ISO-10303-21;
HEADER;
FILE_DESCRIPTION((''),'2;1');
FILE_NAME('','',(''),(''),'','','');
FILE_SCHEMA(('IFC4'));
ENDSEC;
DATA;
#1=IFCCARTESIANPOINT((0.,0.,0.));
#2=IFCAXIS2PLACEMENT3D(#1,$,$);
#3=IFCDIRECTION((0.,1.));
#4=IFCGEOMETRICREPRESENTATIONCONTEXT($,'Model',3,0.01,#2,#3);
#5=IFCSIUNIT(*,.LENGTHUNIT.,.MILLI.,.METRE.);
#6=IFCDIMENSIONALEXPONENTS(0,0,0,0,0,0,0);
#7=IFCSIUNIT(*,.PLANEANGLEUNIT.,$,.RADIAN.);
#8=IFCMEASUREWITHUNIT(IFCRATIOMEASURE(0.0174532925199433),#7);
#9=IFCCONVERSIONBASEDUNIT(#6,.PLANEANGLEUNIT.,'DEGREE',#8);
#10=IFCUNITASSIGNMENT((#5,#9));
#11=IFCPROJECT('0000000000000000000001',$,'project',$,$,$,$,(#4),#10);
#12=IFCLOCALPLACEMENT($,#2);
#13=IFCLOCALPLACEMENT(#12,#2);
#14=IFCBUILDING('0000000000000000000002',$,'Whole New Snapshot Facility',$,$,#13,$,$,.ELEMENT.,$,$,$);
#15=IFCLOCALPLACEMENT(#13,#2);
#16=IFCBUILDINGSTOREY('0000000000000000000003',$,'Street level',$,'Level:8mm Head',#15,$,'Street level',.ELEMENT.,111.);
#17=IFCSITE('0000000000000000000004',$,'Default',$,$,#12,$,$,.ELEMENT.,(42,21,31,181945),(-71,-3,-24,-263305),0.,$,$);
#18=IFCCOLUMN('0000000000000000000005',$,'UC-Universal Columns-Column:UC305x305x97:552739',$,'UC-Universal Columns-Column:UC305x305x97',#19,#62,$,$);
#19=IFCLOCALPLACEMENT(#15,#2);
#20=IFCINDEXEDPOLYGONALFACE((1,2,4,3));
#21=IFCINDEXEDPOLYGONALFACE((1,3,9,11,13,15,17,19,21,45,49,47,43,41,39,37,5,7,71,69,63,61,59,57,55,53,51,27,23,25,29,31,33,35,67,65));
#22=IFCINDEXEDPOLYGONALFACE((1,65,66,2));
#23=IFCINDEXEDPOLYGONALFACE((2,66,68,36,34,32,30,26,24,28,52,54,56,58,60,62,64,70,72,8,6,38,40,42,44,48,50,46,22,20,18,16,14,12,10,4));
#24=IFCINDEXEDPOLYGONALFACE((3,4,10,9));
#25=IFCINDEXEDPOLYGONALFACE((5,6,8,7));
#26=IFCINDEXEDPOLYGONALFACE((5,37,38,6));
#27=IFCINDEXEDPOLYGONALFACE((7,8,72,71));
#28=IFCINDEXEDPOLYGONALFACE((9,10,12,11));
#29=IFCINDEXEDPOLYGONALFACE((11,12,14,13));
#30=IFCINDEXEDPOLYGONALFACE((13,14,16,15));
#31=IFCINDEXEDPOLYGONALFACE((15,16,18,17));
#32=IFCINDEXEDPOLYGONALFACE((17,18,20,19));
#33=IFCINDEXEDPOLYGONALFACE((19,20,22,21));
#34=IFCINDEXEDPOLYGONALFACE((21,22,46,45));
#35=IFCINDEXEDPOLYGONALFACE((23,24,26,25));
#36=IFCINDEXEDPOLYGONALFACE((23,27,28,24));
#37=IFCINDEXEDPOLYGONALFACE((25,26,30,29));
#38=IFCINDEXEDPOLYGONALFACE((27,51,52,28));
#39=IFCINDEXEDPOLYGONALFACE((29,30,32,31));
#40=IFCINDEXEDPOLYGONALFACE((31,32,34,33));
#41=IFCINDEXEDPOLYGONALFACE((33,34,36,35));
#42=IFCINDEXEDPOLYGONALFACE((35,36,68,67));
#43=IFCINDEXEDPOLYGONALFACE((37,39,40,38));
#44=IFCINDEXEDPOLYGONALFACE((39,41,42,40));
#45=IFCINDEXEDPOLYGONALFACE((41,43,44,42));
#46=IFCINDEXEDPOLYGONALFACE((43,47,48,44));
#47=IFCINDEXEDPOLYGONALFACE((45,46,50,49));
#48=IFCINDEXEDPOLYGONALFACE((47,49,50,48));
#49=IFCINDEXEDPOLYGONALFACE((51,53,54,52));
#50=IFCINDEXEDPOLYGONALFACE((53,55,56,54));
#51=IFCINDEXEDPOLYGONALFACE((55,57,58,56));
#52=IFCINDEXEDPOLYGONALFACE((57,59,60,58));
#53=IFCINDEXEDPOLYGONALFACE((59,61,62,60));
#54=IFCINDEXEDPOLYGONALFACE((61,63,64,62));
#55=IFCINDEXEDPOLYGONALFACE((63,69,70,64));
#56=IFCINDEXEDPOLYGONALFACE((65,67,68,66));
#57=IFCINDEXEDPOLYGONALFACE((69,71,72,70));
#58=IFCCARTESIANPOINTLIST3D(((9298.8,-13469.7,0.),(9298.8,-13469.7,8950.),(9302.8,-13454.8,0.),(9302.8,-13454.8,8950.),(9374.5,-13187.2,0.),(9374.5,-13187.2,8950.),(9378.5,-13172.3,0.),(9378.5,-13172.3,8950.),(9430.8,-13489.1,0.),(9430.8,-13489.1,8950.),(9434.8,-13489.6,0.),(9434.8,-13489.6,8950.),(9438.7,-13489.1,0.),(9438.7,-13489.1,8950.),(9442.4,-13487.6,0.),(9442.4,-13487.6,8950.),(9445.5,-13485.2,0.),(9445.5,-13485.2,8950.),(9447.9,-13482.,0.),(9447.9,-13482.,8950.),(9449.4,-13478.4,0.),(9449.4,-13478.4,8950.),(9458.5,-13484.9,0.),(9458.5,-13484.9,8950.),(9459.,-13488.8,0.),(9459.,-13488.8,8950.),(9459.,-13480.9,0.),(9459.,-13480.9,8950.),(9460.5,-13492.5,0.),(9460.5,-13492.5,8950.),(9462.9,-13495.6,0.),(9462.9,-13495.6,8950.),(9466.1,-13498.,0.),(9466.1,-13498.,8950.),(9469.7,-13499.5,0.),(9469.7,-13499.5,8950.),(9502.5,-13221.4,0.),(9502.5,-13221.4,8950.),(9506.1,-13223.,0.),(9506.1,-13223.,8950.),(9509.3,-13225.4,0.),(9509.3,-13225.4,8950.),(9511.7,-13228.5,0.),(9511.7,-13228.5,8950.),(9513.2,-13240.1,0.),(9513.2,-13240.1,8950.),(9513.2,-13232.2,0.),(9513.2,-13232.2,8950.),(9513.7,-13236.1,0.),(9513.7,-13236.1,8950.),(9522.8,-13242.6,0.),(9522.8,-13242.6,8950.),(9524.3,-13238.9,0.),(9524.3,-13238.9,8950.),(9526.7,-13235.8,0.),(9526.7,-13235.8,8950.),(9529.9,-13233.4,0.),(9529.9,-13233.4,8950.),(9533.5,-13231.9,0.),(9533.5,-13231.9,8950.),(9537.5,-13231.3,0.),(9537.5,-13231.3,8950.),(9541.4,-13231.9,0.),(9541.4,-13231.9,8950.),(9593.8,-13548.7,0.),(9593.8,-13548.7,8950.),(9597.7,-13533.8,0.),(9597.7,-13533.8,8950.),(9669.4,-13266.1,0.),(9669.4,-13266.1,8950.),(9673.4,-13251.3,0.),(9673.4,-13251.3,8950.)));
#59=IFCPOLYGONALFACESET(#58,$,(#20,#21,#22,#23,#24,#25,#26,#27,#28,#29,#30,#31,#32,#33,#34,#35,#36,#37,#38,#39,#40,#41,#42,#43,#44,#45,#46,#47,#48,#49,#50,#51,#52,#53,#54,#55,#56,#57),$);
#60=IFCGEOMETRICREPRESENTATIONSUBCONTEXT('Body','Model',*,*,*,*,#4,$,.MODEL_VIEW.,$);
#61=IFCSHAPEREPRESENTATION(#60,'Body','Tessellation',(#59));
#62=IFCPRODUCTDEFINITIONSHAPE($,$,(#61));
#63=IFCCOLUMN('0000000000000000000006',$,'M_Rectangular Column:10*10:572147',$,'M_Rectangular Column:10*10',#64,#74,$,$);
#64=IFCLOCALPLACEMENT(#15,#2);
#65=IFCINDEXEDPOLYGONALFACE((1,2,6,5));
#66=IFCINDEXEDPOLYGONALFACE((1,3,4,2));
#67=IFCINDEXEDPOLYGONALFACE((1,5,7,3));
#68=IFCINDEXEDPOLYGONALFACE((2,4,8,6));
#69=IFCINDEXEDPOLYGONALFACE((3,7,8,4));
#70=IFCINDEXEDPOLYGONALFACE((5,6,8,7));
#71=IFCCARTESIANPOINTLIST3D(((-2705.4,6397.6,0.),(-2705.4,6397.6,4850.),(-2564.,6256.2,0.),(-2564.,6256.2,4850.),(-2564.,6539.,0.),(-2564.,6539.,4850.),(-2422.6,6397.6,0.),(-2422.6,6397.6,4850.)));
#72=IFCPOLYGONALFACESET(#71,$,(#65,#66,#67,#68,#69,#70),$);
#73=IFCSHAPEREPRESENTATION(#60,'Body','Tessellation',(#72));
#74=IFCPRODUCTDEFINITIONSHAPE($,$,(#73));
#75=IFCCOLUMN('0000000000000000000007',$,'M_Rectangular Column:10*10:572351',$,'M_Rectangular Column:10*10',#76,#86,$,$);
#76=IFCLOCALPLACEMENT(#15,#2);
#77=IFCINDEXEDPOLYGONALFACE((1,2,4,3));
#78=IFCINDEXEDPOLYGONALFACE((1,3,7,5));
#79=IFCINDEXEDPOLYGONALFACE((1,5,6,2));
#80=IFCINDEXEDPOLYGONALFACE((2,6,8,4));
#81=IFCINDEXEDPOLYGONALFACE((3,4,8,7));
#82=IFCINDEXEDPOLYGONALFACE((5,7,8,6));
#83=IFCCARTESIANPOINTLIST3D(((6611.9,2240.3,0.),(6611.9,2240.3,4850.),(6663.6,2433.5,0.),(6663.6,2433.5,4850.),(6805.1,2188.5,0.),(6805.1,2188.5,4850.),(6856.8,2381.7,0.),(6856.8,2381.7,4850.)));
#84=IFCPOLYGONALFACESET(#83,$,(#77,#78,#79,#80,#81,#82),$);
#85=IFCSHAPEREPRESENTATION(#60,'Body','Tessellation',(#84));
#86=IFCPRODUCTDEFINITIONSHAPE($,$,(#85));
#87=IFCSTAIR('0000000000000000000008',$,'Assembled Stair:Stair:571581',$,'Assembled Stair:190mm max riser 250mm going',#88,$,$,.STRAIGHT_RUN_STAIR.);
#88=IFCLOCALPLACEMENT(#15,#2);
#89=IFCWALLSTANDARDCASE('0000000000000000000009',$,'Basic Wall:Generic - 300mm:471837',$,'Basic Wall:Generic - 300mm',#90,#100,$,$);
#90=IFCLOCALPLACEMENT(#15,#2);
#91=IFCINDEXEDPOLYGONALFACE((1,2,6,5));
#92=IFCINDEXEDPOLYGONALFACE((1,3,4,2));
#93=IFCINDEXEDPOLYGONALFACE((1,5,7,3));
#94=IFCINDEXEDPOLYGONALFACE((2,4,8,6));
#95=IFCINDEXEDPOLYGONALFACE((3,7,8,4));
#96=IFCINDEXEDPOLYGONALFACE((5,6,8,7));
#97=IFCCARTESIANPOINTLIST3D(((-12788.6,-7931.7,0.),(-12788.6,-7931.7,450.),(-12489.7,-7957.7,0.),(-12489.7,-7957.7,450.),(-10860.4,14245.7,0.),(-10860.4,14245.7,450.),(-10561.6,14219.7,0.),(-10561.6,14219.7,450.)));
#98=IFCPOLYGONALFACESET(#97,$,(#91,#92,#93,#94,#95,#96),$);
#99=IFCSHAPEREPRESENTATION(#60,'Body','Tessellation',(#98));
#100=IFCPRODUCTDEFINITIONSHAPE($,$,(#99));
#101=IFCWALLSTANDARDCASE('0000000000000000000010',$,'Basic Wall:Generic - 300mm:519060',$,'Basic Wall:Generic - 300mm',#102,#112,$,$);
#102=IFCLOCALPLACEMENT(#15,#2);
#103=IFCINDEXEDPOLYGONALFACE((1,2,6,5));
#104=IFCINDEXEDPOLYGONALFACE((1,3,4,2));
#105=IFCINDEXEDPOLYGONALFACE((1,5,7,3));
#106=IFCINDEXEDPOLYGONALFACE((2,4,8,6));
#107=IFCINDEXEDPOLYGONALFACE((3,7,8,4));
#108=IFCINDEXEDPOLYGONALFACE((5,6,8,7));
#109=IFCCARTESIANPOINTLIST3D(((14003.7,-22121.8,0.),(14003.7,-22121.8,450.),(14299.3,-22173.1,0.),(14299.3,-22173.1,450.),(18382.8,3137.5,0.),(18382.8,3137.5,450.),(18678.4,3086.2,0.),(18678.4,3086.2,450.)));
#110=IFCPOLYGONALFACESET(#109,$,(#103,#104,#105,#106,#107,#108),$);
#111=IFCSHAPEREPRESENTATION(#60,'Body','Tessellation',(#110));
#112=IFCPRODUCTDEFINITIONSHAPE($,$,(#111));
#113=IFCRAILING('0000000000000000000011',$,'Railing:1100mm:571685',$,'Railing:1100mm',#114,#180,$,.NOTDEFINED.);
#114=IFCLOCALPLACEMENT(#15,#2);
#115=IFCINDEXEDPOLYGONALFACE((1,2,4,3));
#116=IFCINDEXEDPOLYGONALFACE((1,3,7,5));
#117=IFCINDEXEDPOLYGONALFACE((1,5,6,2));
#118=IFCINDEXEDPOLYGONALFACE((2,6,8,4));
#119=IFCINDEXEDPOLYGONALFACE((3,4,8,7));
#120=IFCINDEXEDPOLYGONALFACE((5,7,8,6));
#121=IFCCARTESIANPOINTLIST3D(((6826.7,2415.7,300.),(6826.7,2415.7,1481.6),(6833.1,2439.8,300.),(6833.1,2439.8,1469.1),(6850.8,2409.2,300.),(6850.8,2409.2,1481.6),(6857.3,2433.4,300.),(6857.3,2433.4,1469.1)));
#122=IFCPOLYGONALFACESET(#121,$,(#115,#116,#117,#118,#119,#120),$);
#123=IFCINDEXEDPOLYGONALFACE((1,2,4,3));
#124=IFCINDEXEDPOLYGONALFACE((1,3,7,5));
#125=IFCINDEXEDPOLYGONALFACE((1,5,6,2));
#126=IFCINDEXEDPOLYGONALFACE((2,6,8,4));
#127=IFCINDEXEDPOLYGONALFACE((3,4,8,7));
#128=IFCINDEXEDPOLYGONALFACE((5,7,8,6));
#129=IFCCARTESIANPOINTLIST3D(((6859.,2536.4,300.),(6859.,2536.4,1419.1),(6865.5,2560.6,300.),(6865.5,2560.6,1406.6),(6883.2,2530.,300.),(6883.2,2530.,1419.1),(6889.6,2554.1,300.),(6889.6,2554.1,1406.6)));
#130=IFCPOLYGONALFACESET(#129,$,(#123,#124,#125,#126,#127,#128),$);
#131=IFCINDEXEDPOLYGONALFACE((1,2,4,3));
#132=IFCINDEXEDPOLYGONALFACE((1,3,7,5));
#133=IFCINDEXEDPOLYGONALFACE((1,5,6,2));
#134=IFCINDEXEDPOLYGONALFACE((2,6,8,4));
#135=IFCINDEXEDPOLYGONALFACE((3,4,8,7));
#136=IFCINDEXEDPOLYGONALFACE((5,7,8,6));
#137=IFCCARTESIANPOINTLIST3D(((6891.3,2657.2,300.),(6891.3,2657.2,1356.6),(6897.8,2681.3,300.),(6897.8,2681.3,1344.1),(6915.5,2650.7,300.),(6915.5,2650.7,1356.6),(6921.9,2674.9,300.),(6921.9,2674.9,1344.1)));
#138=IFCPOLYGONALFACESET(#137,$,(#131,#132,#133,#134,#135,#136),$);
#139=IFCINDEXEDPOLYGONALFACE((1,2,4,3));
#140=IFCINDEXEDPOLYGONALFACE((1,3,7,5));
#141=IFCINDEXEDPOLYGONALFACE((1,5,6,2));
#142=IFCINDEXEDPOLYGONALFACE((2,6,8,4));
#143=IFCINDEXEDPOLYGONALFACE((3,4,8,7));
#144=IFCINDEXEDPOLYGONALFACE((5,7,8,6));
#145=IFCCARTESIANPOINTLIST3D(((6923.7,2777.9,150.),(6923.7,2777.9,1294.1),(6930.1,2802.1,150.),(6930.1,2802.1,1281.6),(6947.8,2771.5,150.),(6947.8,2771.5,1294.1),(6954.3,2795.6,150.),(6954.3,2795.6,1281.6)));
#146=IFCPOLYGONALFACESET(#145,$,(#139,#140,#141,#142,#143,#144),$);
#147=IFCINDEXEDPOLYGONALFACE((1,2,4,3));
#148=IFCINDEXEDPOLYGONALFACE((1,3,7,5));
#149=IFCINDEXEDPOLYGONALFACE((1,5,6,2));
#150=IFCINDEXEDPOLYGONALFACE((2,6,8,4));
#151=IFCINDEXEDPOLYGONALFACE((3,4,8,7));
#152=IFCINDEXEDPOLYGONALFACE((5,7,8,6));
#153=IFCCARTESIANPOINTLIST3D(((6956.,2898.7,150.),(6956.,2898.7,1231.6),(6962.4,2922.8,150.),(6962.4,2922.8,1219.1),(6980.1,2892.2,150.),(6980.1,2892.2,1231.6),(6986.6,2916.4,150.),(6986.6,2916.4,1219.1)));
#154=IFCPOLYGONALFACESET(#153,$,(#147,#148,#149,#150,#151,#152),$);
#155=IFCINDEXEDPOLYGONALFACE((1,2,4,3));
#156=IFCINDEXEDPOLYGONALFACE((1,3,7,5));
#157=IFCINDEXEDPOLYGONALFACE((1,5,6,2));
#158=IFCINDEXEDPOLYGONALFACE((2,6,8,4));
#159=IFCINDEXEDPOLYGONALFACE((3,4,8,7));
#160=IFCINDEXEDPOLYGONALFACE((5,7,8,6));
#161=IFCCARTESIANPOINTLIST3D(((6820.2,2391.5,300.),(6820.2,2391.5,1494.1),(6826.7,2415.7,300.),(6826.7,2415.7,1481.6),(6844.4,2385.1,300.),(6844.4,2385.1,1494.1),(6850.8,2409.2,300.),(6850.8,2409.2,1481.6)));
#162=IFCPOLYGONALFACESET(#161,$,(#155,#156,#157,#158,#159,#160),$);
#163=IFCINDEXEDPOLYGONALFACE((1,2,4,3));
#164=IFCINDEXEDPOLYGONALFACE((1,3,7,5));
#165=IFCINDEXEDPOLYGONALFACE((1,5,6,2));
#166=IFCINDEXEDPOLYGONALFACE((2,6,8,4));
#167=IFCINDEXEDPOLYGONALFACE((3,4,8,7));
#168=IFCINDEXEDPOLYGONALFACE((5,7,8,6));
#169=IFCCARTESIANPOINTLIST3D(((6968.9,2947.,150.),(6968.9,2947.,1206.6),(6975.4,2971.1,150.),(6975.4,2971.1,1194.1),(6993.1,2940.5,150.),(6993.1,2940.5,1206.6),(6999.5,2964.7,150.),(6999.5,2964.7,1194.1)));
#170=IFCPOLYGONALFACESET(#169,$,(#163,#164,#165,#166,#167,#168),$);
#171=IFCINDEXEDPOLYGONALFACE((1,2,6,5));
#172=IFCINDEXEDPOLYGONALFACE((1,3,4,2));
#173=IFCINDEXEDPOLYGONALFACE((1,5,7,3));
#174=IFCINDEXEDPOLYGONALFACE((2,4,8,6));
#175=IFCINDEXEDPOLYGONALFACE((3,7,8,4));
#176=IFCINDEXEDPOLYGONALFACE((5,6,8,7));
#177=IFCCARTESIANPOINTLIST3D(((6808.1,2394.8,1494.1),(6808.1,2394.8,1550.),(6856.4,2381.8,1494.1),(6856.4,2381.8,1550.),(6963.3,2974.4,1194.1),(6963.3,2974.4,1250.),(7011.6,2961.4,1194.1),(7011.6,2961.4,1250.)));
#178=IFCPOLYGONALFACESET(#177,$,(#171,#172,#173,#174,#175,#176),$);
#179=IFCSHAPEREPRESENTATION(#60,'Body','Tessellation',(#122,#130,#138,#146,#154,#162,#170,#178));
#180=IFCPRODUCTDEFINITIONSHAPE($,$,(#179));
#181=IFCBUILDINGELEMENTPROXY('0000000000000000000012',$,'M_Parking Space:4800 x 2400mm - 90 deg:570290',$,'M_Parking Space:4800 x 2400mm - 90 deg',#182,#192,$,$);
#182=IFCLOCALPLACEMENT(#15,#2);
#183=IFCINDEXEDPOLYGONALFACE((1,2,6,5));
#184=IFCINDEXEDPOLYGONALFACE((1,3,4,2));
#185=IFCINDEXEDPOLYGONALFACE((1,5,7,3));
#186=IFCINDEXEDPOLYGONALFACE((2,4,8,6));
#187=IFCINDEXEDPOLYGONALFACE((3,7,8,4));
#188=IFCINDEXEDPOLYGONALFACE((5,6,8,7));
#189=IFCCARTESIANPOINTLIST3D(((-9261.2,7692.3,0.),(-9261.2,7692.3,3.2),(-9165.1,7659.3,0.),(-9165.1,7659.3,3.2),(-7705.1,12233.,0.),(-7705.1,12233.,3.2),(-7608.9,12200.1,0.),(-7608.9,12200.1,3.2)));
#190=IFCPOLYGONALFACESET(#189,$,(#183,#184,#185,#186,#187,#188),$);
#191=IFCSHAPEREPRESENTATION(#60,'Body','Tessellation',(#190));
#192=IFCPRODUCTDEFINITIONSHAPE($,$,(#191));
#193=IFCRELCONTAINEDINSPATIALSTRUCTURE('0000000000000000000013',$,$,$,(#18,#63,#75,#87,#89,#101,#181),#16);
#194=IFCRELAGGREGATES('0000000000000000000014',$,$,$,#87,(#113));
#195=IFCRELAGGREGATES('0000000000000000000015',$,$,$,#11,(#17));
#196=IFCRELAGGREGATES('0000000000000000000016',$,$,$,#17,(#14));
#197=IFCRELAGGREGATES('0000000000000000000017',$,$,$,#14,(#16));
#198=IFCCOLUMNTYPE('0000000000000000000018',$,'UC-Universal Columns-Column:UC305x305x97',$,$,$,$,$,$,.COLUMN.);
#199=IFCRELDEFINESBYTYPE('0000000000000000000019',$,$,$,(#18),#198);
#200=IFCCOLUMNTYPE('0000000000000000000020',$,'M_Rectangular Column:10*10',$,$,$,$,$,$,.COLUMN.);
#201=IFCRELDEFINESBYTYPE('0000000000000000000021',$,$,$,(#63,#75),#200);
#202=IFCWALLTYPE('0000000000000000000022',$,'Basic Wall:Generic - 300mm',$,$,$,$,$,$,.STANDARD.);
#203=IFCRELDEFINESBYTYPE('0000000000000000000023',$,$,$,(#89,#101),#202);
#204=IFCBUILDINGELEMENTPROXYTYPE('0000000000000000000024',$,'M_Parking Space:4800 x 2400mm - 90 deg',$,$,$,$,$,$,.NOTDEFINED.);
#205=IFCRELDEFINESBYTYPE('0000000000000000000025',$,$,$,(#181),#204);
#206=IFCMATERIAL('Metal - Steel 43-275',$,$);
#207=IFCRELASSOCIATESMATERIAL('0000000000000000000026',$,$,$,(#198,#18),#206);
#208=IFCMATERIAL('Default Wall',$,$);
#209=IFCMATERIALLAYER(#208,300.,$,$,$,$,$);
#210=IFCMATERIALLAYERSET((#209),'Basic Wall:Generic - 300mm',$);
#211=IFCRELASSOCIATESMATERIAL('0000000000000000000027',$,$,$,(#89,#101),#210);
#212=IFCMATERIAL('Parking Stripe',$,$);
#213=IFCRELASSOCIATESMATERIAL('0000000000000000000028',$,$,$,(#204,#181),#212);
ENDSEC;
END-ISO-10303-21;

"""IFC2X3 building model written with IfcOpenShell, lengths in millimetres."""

from ifc_helpers import new_model, entity, si_unit, converted_unit, direction, frame, frame_2d, origin, origin_2d_with_axis, place, context, subcontext, project, spatial, polyline, rectangle, i_section, outline, extrude, source, transform, mapped, material, layer, layer_set, layer_usage, type_object, type_shapes, element, aggregate, save


model = new_model("IFC2X3")

# Units and contexts
model_context = context("Model", 3, precision=0.01, world=origin(), true_north=direction((0.0, 1.0)))
body_context = subcontext(model_context, "Body", "Model", "MODEL_VIEW")
ifc_project = project(units=[si_unit("LENGTHUNIT", "METRE", prefix="MILLI"), converted_unit("PLANEANGLEUNIT", "DEGREE", entity("IfcRatioMeasure", 0.0174532925199433), si_unit("PLANEANGLEUNIT", "RADIAN"), dimensions=[0, 0, 0, 0, 0, 0, 0])], contexts=[model_context])

# Site, building, storey
site_placement = place(None, origin())
site = spatial("IfcSite", under=ifc_project, at=site_placement, Name="Default", CompositionType="ELEMENT", RefLatitude=(42, 21, 31, 181945), RefLongitude=(-71, -3, -24, -263305), RefElevation=0.0)
building_placement = place(site_placement, origin())
building = spatial("IfcBuilding", under=site, at=building_placement, Name="Whole New Snapshot Facility", CompositionType="ELEMENT")
storey_placement = place(building_placement, origin())
storey = spatial("IfcBuildingStorey", under=building, at=storey_placement, Name="Street level", ObjectType="Level:8mm Head", LongName="Street level", CompositionType="ELEMENT", Elevation=111.0)

# Columns
ifc_material_1 = material(Name="Metal - Steel 43-275")
column_type_1 = type_object("IfcColumnType", Name="UC-Universal Columns-Column:UC305x305x97", PredefinedType="COLUMN", material=ifc_material_1)
shared_shape_1 = source(origin(), body_context, "Body", "SweptSolid", [
    extrude(i_section(OverallWidth=305.3, OverallDepth=307.9, WebThickness=9.9, FlangeThickness=15.4, FilletRadius=15.2, at=frame_2d((0.0, 0.0), x_axis=(0.0, 1.0))), frame((0.0, 0.0, 0.0), z_axis=(0.0, 0.0, 1.0), x_axis=(0.0, -1.0, 0.0)), (0.0, 0.0, 1.0), 8950.0),
])
type_shapes(column_type_1, [shared_shape_1])
column_placement = place(storey_placement, frame((9486.1, -13360.5, 0.0), z_axis=(0.0, 0.0, 1.0), x_axis=(0.965983, -0.258607, 0.0)))
element("IfcColumn", 1, at=column_placement, inside=storey, type_object=column_type_1, material=ifc_material_1, Name="UC-Universal Columns-Column:UC305x305x97:552739", ObjectType="UC-Universal Columns-Column:UC305x305x97", context=body_context, shape_type="MappedRepresentation", body=[
    mapped(shared_shape_1, transform((0.0, 0.0, 0.0), scale=1.0)),
])
column_type_2 = type_object("IfcColumnType", Name="M_Rectangular Column:10*10", PredefinedType="COLUMN")
shared_shape_2 = source(origin(), body_context, "Body", "SweptSolid", [
    extrude(rectangle(XDim=200.0, YDim=200.0, at=origin_2d_with_axis()), frame((0.0, 0.0, 0.0), z_axis=(0.0, 0.0, 1.0), x_axis=(0.0, -1.0, 0.0)), (0.0, 0.0, 1.0), 4850.0),
])
type_shapes(column_type_2, [shared_shape_2])
for number, where, z_axis, x_axis, name in (
    (2, (-2564.0, 6397.6, 0.0), (0.0, 0.0, 1.0), (0.707107, 0.707107, 0.0), "M_Rectangular Column:10*10:572147"),
    (3, (6734.4, 2311.0, 0.0), (0.0, 0.0, 1.0), (0.258607, 0.965983, 0.0), "M_Rectangular Column:10*10:572351"),
):
    element("IfcColumn", number, at=place(storey_placement, frame(where, z_axis=z_axis, x_axis=x_axis)), inside=storey, type_object=column_type_2, Name=name, ObjectType="M_Rectangular Column:10*10", context=body_context, shape_type="MappedRepresentation", body=[
        mapped(shared_shape_2, transform((0.0, 0.0, 0.0), scale=1.0)),
    ])

# Stair
stair_placement = place(storey_placement, origin())
stair = element("IfcStair", 4, at=stair_placement, inside=storey, Name="Assembled Stair:Stair:571581", ObjectType="Assembled Stair:190mm max riser 250mm going", ShapeType="STRAIGHT_RUN_STAIR")

# Walls
ifc_material_2 = material(Name="Default Wall")
ifc_layer_1 = layer(ifc_material_2, 300.0)
ifc_layer_set_1 = layer_set([ifc_layer_1], Name="Basic Wall:Generic - 300mm")
ifc_layer_usage_1 = layer_usage(ifc_layer_set_1, "AXIS2", "NEGATIVE", 150.0)
wall_type = type_object("IfcWallType", Name="Basic Wall:Generic - 300mm", PredefinedType="STANDARD")
wall_1_placement = place(storey_placement, frame((-10711.0, 14232.7, 0.0), z_axis=(0.0, 0.0, 1.0), x_axis=(-0.086615, -0.996242, 0.0)))
element("IfcWallStandardCase", 5, at=wall_1_placement, inside=storey, type_object=wall_type, material=ifc_layer_usage_1, Name="Basic Wall:Generic - 300mm:471837", ObjectType="Basic Wall:Generic - 300mm", context=body_context, shape_type="SweptSolid", body=[
    extrude(rectangle(XDim=22261.1, YDim=300.0, at=frame_2d((11130.5, 0.0), x_axis=(-1.0, 0.0))), origin(), (0.0, 0.0, 1.0), 450.0),
])
ifc_layer_usage_2 = layer_usage(ifc_layer_set_1, "AXIS2", "NEGATIVE", 150.0)
wall_2_placement = place(storey_placement, frame((14151.5, -22147.4, 0.0), z_axis=(0.0, 0.0, 1.0), x_axis=(0.17082, 0.985302, 0.0)))
element("IfcWallStandardCase", 6, at=wall_2_placement, inside=storey, type_object=wall_type, material=ifc_layer_usage_2, Name="Basic Wall:Generic - 300mm:519060", ObjectType="Basic Wall:Generic - 300mm", context=body_context, shape_type="SweptSolid", body=[
    extrude(rectangle(XDim=25636.1, YDim=300.0, at=frame_2d((12818.0, 0.0), x_axis=(-1.0, 0.0))), origin(), (0.0, 0.0, 1.0), 450.0),
])

# Railing
railing_placement = place(stair_placement, origin())
railing = element("IfcRailing", 7, at=railing_placement, Name="Railing:1100mm:571685", ObjectType="Railing:1100mm", PredefinedType="NOTDEFINED", context=body_context, shape_type="SweptSolid", body=[
    extrude(outline(polyline([(-587.7, -12.5), (581.4, -12.5), (593.9, 12.5), (-587.7, 12.5), (-587.7, -12.5)])), frame((6829.9, 2427.8, 887.7), z_axis=(0.965983, -0.258606, 0.0), x_axis=(0.0, 0.0, 1.0)), (0.0, 0.0, 1.0), 25.0),
    extrude(outline(polyline([(-556.4, -12.5), (550.2, -12.5), (562.7, 12.5), (-556.4, 12.5), (-556.4, -12.5)])), frame((6862.2, 2548.5, 856.4), z_axis=(0.965983, -0.258606, 0.0), x_axis=(0.0, 0.0, 1.0)), (0.0, 0.0, 1.0), 25.0),
    extrude(outline(polyline([(-525.2, -12.5), (518.9, -12.5), (531.4, 12.5), (-525.2, 12.5), (-525.2, -12.5)])), frame((6894.6, 2669.3, 825.2), z_axis=(0.965983, -0.258606, 0.0), x_axis=(0.0, 0.0, 1.0)), (0.0, 0.0, 1.0), 25.0),
    extrude(outline(polyline([(-568.9, -12.5), (562.7, -12.5), (575.2, 12.5), (-568.9, 12.5), (-568.9, -12.5)])), frame((6926.9, 2790.0, 718.9), z_axis=(0.965983, -0.258606, 0.0), x_axis=(0.0, 0.0, 1.0)), (0.0, 0.0, 1.0), 25.0),
    extrude(outline(polyline([(-537.7, -12.5), (531.4, -12.5), (543.9, 12.5), (-537.7, 12.5), (-537.7, -12.5)])), frame((6959.2, 2910.8, 687.7), z_axis=(0.965983, -0.258606, 0.0), x_axis=(0.0, 0.0, 1.0)), (0.0, 0.0, 1.0), 25.0),
    extrude(outline(polyline([(-593.9, -12.5), (587.7, -12.5), (600.2, 12.5), (-593.9, 12.5), (-593.9, -12.5)])), frame((6823.4, 2403.6, 893.9), z_axis=(0.965983, -0.258606, 0.0), x_axis=(0.0, 0.0, 1.0)), (0.0, 0.0, 1.0), 25.0),
    extrude(outline(polyline([(-525.2, -12.5), (518.9, -12.5), (531.4, 12.5), (-525.2, 12.5), (-525.2, -12.5)])), frame((6972.1, 2959.1, 675.2), z_axis=(0.965983, -0.258606, 0.0), x_axis=(0.0, 0.0, 1.0)), (0.0, 0.0, 1.0), 25.0),
    extrude(outline(polyline([(-322.9, -25.0), (347.9, -25.0), (322.9, 25.0), (-347.9, 25.0), (-322.9, -25.0)])), frame((6885.7, 2684.6, 1372.0), z_axis=(0.965983, -0.258606, 0.0), x_axis=(-0.231304, -0.864001, 0.447214)), (0.0, 0.0, 1.0), 50.0),
])
aggregate(stair, [railing])

# Building element proxy
ifc_material_3 = material(Name="Parking Stripe")
building_element_proxy_type = type_object("IfcBuildingElementProxyType", Name="M_Parking Space:4800 x 2400mm - 90 deg", PredefinedType="NOTDEFINED", material=ifc_material_3)
shared_shape_3 = source(origin(), body_context, "Body", "SweptSolid", [
    extrude(rectangle(XDim=101.6, YDim=4800.0, at=origin_2d_with_axis()), frame((0.0, 2400.0, 0.0)), (0.0, 0.0, 1.0), 3.2),
])
type_shapes(building_element_proxy_type, [shared_shape_3])
for number, where, z_axis, x_axis, name in (
    (8, (-9213.1, 7675.8, 0.0), (0.0, 0.0, 1.0), (0.945989, -0.324198, 0.0), "M_Parking Space:4800 x 2400mm - 90 deg:570290"),
):
    element("IfcBuildingElementProxy", number, at=place(storey_placement, frame(where, z_axis=z_axis, x_axis=x_axis)), inside=storey, type_object=building_element_proxy_type, material=ifc_material_3, Name=name, ObjectType="M_Parking Space:4800 x 2400mm - 90 deg", context=body_context, shape_type="MappedRepresentation", body=[
        mapped(shared_shape_3, transform((0.0, 0.0, 0.0), scale=1.0)),
    ])

save(model, "model.ifc")
